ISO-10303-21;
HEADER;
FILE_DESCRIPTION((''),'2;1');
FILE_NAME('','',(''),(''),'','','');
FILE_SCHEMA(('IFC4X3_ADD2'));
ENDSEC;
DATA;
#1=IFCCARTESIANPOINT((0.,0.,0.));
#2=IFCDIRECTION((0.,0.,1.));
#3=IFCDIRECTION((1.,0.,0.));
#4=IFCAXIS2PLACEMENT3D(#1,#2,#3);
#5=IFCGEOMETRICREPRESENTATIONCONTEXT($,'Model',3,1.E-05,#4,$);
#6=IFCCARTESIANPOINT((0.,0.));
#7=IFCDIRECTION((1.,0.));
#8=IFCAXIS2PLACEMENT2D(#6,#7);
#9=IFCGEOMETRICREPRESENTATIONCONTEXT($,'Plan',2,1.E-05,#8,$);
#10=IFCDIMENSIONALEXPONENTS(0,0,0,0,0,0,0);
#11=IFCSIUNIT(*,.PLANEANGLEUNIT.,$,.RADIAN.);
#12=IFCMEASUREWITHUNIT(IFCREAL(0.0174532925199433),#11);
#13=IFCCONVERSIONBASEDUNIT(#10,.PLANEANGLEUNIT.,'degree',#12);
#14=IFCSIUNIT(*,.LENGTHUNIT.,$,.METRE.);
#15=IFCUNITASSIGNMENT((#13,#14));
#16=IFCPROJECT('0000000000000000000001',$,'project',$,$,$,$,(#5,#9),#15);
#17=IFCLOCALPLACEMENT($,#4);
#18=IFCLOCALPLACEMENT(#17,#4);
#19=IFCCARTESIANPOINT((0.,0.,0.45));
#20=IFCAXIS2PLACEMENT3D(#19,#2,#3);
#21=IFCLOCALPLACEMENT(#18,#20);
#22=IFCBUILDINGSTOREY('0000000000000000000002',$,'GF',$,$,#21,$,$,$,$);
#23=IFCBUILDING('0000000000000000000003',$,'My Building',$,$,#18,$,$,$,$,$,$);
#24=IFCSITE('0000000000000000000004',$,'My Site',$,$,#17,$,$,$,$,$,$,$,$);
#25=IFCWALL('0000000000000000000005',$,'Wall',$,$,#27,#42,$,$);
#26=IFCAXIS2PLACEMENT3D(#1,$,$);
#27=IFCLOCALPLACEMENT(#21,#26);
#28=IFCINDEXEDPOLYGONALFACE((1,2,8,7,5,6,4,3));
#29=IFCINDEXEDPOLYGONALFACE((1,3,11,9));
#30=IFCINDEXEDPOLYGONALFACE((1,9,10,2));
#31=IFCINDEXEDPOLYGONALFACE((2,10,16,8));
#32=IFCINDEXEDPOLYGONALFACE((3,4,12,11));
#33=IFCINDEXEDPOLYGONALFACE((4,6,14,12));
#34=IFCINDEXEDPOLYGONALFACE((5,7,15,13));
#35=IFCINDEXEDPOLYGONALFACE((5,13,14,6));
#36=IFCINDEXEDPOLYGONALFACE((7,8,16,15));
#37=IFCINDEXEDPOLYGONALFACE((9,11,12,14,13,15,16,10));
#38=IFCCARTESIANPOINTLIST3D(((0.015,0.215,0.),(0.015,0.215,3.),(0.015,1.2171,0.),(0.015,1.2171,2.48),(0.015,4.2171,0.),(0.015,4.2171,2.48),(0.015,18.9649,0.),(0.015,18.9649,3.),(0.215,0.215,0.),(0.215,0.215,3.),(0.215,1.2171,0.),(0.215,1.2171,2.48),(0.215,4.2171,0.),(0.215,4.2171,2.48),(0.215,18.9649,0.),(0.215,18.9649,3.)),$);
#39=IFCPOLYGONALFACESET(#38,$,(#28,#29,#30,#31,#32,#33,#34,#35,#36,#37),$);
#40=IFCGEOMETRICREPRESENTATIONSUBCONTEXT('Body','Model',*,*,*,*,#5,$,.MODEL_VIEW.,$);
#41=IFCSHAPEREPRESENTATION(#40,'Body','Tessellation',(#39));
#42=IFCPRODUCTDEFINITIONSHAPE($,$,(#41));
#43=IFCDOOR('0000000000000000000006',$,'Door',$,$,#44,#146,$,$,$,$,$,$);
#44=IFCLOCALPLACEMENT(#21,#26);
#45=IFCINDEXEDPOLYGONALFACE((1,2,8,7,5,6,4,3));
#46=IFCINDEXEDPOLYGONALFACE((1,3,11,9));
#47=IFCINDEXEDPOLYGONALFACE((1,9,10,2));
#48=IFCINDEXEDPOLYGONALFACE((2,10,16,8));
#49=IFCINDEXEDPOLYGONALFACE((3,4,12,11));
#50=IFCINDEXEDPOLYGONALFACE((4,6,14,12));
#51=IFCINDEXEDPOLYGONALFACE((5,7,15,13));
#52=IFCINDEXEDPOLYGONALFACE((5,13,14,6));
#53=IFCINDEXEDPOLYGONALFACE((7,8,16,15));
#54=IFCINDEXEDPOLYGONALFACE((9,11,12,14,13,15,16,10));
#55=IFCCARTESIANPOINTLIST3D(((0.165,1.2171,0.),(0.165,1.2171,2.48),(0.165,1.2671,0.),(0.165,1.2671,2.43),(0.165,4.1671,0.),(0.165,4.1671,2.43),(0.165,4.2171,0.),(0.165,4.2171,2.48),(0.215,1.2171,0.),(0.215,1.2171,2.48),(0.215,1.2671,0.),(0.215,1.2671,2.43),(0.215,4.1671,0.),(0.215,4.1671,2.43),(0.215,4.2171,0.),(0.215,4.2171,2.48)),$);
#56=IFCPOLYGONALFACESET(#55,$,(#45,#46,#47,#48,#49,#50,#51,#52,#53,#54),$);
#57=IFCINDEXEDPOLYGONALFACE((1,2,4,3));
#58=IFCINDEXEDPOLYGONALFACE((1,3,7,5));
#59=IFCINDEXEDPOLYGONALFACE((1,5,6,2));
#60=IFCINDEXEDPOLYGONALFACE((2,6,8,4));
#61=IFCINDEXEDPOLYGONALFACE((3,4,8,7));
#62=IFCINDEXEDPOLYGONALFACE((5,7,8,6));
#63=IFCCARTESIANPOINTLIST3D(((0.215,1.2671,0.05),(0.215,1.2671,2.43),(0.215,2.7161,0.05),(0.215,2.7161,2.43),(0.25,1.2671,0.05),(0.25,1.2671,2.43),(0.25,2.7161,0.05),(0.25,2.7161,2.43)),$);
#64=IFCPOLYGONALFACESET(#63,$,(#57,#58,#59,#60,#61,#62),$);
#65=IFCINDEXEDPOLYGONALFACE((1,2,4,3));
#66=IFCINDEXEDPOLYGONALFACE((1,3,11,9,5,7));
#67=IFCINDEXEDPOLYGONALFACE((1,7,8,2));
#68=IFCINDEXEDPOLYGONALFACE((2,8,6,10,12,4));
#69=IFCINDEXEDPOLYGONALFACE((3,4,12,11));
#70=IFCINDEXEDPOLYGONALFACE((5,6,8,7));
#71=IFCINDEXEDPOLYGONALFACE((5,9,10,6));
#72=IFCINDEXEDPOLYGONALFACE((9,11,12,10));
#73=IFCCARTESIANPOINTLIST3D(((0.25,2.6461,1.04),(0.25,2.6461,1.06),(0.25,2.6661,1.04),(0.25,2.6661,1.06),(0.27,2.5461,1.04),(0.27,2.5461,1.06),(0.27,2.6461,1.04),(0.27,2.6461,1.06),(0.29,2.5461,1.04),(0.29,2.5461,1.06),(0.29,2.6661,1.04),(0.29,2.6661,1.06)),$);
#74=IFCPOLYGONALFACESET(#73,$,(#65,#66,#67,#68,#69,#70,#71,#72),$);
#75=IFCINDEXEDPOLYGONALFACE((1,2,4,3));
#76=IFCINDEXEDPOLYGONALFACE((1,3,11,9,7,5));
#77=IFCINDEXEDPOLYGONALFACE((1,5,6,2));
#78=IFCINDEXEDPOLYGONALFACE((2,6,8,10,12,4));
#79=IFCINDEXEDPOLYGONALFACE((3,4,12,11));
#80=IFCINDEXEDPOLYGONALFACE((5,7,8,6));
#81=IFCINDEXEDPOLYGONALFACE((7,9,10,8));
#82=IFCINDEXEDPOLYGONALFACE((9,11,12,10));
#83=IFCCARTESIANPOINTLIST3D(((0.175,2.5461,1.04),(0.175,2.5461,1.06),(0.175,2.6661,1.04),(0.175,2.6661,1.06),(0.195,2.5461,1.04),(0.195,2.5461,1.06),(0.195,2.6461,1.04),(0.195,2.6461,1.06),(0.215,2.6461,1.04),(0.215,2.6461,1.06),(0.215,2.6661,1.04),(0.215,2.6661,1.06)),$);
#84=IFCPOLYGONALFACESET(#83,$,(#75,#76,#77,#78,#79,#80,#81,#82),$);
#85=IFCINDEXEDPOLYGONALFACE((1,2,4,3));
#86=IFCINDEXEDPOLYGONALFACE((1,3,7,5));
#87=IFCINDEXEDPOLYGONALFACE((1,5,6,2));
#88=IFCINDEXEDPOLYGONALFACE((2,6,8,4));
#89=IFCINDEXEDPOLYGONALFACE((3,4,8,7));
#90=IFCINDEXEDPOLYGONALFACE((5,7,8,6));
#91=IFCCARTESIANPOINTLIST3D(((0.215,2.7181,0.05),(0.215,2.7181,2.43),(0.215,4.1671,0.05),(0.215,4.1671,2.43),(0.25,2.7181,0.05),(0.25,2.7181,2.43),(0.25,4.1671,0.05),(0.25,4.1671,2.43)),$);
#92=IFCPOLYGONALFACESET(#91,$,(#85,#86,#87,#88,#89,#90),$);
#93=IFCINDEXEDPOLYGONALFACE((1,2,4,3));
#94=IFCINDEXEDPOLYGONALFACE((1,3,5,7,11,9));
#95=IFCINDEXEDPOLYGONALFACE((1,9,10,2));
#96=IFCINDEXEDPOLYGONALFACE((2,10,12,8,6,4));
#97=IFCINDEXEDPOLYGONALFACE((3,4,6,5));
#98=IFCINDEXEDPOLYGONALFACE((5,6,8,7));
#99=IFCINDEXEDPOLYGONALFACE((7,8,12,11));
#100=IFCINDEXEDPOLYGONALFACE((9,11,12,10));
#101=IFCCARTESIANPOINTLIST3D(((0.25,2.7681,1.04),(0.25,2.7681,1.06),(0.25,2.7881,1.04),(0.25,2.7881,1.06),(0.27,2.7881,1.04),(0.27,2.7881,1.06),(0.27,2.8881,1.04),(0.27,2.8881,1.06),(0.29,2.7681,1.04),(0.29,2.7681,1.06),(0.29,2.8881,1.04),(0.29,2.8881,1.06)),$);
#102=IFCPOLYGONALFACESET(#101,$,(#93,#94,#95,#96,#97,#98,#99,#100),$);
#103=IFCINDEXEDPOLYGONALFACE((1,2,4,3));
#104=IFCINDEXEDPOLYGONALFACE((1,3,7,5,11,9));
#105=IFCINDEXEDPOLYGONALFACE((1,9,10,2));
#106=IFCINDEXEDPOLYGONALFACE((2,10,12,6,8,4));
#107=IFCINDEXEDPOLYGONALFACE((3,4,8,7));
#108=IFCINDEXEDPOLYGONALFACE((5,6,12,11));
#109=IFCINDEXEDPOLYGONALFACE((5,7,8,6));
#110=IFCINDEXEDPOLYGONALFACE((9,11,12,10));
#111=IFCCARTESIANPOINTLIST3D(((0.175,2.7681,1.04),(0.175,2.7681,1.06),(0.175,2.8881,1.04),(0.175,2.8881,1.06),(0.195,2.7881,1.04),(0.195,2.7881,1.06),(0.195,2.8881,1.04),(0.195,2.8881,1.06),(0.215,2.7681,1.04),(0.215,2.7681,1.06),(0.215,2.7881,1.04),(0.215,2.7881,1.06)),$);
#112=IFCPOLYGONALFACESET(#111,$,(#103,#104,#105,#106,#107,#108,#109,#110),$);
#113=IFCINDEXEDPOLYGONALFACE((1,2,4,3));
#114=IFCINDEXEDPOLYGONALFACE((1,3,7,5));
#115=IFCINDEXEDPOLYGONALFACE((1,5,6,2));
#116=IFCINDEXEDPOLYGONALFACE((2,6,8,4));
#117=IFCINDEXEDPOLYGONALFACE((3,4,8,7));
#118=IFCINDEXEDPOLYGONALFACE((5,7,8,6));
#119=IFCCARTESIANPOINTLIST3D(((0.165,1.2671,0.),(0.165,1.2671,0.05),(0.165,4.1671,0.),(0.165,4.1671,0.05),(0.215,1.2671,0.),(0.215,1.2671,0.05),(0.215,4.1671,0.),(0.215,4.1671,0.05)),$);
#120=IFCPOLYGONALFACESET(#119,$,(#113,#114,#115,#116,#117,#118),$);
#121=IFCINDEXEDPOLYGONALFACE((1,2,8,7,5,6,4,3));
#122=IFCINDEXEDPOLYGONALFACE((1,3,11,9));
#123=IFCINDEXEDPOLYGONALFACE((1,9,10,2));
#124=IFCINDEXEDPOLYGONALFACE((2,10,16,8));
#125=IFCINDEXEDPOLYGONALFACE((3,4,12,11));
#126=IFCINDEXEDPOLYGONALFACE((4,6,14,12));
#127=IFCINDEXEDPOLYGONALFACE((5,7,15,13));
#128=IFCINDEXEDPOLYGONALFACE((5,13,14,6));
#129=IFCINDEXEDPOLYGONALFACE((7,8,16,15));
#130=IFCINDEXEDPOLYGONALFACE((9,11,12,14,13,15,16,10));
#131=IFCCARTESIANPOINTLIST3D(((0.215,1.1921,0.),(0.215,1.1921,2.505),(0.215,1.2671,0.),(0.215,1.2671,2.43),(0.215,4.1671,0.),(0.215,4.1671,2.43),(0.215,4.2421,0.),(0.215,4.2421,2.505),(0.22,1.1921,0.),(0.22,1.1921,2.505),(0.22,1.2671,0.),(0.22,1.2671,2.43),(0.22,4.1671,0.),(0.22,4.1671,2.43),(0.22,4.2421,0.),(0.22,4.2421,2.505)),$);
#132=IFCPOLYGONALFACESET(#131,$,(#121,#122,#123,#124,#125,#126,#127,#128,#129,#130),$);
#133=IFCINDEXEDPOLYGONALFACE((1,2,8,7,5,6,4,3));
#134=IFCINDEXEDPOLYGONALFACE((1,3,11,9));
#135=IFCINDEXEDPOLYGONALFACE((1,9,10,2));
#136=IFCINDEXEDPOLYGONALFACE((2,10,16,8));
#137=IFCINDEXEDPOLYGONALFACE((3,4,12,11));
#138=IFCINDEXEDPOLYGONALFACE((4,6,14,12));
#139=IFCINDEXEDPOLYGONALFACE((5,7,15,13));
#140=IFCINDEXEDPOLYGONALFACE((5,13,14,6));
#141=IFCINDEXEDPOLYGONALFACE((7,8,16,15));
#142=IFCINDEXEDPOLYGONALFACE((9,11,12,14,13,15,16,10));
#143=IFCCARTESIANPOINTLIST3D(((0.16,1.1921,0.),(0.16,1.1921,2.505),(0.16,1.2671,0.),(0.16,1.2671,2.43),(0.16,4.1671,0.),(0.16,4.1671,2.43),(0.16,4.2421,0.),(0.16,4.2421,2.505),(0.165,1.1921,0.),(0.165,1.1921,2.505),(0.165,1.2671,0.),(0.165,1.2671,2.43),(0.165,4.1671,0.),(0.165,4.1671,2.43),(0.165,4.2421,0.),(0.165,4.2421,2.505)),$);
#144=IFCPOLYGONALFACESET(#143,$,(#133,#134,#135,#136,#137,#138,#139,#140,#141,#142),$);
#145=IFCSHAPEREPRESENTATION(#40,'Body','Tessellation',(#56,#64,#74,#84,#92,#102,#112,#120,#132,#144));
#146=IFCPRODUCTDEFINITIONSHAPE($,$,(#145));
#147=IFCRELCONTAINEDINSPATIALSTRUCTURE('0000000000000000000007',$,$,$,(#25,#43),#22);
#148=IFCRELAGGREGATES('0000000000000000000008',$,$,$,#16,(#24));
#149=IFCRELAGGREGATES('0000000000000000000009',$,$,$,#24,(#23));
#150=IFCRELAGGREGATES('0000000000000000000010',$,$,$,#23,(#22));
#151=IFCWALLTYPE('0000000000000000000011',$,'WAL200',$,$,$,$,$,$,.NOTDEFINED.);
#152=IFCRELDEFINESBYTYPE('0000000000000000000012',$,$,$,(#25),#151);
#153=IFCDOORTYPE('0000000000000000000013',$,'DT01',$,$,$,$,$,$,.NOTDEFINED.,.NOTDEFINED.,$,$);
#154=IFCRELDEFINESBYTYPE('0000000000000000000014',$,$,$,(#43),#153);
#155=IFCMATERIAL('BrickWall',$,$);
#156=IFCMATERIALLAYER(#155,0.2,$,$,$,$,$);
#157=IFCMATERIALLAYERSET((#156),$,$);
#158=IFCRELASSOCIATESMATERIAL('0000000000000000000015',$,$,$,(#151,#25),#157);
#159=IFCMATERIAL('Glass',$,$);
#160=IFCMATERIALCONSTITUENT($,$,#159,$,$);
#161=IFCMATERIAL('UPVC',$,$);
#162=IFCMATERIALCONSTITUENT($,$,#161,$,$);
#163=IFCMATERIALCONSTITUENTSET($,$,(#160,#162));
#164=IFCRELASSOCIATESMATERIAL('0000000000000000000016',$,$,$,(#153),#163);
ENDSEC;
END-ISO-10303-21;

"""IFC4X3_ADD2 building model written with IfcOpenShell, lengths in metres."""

from ifc_helpers import new_model, entity, si_unit, converted_unit, frame, origin_with_axes, origin_2d_with_axis, place, context, subcontext, project, spatial, line, indexed_curve, outline, extrude, shape, source, transform, mapped, material, layer, layer_set, layer_usage, constituent, constituent_set, type_object, type_shapes, element, fill, save


model = new_model("IFC4X3_ADD2")

# Units and contexts
model_context = context("Model", 3, precision=1e-05, world=origin_with_axes())
plan_context = context("Plan", 2, precision=1e-05, world=origin_2d_with_axis())
body_context_1 = subcontext(model_context, "Body", "Model", "MODEL_VIEW")
body_context_2 = subcontext(plan_context, "Body", "Plan", "PLAN_VIEW")
ifc_project = project(units=[converted_unit("PLANEANGLEUNIT", "degree", entity("IfcReal", 0.0174532925199433), si_unit("PLANEANGLEUNIT", "RADIAN"), dimensions=[0, 0, 0, 0, 0, 0, 0]), si_unit("LENGTHUNIT", "METRE")], contexts=[model_context, plan_context])

# Site, building, storey
site_placement = place(None, origin_with_axes())
site = spatial("IfcSite", under=ifc_project, at=site_placement, Name="My Site")
building_placement = place(site_placement, origin_with_axes())
building = spatial("IfcBuilding", under=site, at=building_placement, Name="My Building")
storey_placement = place(building_placement, frame((0.0, 0.0, 0.45), z_axis=(0.0, 0.0, 1.0), x_axis=(1.0, 0.0, 0.0)))
storey = spatial("IfcBuildingStorey", under=building, at=storey_placement, Name="GF")

# Shared definitions
ifc_material_1 = material(Name="BrickWall")

# Wall, opening, door
ifc_layer_1 = layer(ifc_material_1, 0.2)
ifc_layer_set_1 = layer_set([ifc_layer_1])
ifc_layer_usage_1 = layer_usage(ifc_layer_set_1, "AXIS2", "POSITIVE", 0.0)
wall_type_1 = type_object("IfcWallType", Name="WAL200", PredefinedType="NOTDEFINED", material=ifc_layer_set_1)
wall_1_placement = place(storey_placement, frame((0.215, 0.215, 0.0), z_axis=(0.0, 0.0, 1.0), x_axis=(0.0, 1.0, 0.0)))
wall_1 = element("IfcWall", 1, at=wall_1_placement, inside=storey, type_object=wall_type_1, material=ifc_layer_usage_1, Name="Wall", context=body_context_1, shape_type="SweptSolid", body=[
    extrude(outline(indexed_curve([(0.0, 0.0), (0.0, 0.2), (18.7499, 0.2), (18.7499, 0.0), (0.0, 0.0)], self_intersect=False)), origin_with_axes(), (0.0, 0.0, 1.0), 3.0),
])
shared_shape_1 = source(origin_with_axes(), body_context_1, "Body", "SweptSolid", [
    extrude(outline(indexed_curve([(0.0, 0.0), (3.0, 0.0), (3.0, 2.48), (0.0, 2.48)], segments=[line(1, 2, 3, 4, 1)])), frame((0.0, -0.6, 0.0), z_axis=(0.0, -1.0, 0.0), x_axis=(1.0, 0.0, 0.0)), (0.0, 0.0, -1.0), 1.2),
])
opening_1_placement = place(wall_1_placement, frame((1.0021, 0.0, 0.0), z_axis=(0.0, 0.0, 1.0), x_axis=(1.0, 0.0, 0.0)))
opening_1 = element("IfcOpeningElement", 2, at=opening_1_placement, cuts=wall_1, PredefinedType="OPENING", context=body_context_1, shape_type="MappedRepresentation", body=[
    mapped(shared_shape_1, transform((0.0, 0.0, 0.0), x_axis=(1.0, 0.0, 0.0), y_axis=(0.0, 1.0, 0.0), z_axis=(0.0, 0.0, 1.0), scale=1.0)),
])
ifc_material_2 = material(Name="Glass")
ifc_constituent_1 = constituent(ifc_material_2)
ifc_material_3 = material(Name="UPVC")
ifc_constituent_2 = constituent(ifc_material_3)
ifc_constituent_set = constituent_set(constituents=[ifc_constituent_1, ifc_constituent_2])
door_type_1 = type_object("IfcDoorType", Name="DT01", OperationType="NOTDEFINED", PredefinedType="NOTDEFINED", material=ifc_constituent_set)
shared_shape_2 = source(origin_with_axes(), body_context_1, "Body", "SweptSolid", [
    extrude(outline(indexed_curve([(3.0, 0.0), (3.0, 2.48), (0.0, 2.48), (0.0, 0.0), (0.05, 0.0), (0.05, 2.43), (2.95, 2.43), (2.95, 0.0)], segments=[line(5, 4), line(4, 3), line(3, 2), line(2, 1), line(1, 8), line(8, 7), line(7, 6), line(6, 5)], self_intersect=False)), frame((0.0, 0.0, 0.0), z_axis=(0.0, -1.0, 0.0), x_axis=(1.0, 0.0, 0.0)), (0.0, 0.0, -1.0), 0.05),
    extrude(outline(indexed_curve([(0.0, 0.0), (1.449, 0.0), (1.449, 0.035), (0.0, 0.035)], segments=[line(1, 2, 3, 4, 1)])), frame((0.05, -0.035, 0.05), z_axis=(0.0, 0.0, 1.0), x_axis=(1.0, 0.0, 0.0)), (0.0, 0.0, 1.0), 2.38),
    extrude(outline(indexed_curve([(0.0, 0.0), (0.0, -0.04), (-0.12, -0.04), (-0.12, -0.02), (-0.02, -0.02), (-0.02, 0.0)], segments=[line(1, 2, 3, 4, 5, 6, 1)])), frame((1.449, -0.035, 1.04), z_axis=(0.0, 0.0, 1.0), x_axis=(1.0, 0.0, 0.0)), (0.0, 0.0, 1.0), 0.02),
    extrude(outline(indexed_curve([(0.0, 0.0), (0.0, 0.04), (-0.12, 0.04), (-0.12, 0.02), (-0.02, 0.02), (-0.02, 0.0)], segments=[line(1, 2, 3, 4, 5, 6, 1)])), frame((1.449, 0.0, 1.04), z_axis=(0.0, 0.0, 1.0), x_axis=(1.0, 0.0, 0.0)), (0.0, 0.0, 1.0), 0.02),
    extrude(outline(indexed_curve([(0.0, 0.0), (-1.449, 0.0), (-1.449, 0.035), (0.0, 0.035)], segments=[line(1, 2, 3, 4, 1)])), frame((2.95, -0.035, 0.05), z_axis=(0.0, 0.0, 1.0), x_axis=(1.0, 0.0, 0.0)), (0.0, 0.0, 1.0), 2.38),
    extrude(outline(indexed_curve([(0.0, 0.0), (0.0, -0.04), (0.12, -0.04), (0.12, -0.02), (0.02, -0.02), (0.02, 0.0)], segments=[line(1, 2, 3, 4, 5, 6, 1)])), frame((1.551, -0.035, 1.04), z_axis=(0.0, 0.0, 1.0), x_axis=(1.0, 0.0, 0.0)), (0.0, 0.0, 1.0), 0.02),
    extrude(outline(indexed_curve([(0.0, 0.0), (0.0, 0.04), (0.12, 0.04), (0.12, 0.02), (0.02, 0.02), (0.02, 0.0)], segments=[line(1, 2, 3, 4, 5, 6, 1)])), frame((1.551, 0.0, 1.04), z_axis=(0.0, 0.0, 1.0), x_axis=(1.0, 0.0, 0.0)), (0.0, 0.0, 1.0), 0.02),
    extrude(outline(indexed_curve([(0.0, 0.0), (2.9, 0.0), (2.9, 0.05), (0.0, 0.05)], segments=[line(1, 2, 3, 4, 1)])), frame((0.05, 0.0, 0.0), z_axis=(0.0, 0.0, 1.0), x_axis=(1.0, 0.0, 0.0)), (0.0, 0.0, 1.0), 0.05),
    extrude(outline(indexed_curve([(0.0, 0.0), (0.0, 2.505), (3.05, 2.505), (3.05, 0.0), (2.975, 0.0), (2.975, 2.43), (0.075, 2.43), (0.075, 0.0)], segments=[line(1, 2, 3, 4, 5, 6, 7, 8, 1)])), frame((-0.025, -0.005, 0.0), z_axis=(0.0, -1.0, 0.0), x_axis=(1.0, 0.0, 0.0)), (0.0, 0.0, -1.0), 0.005),
    extrude(outline(indexed_curve([(0.0, 0.0), (0.0, 2.505), (3.05, 2.505), (3.05, 0.0), (2.975, 0.0), (2.975, 2.43), (0.075, 2.43), (0.075, 0.0)], segments=[line(1, 2, 3, 4, 5, 6, 7, 8, 1)])), frame((-0.025, 0.05, 0.0), z_axis=(0.0, -1.0, 0.0), x_axis=(1.0, 0.0, 0.0)), (0.0, 0.0, -1.0), 0.005),
])
shared_shape_3 = source(origin_with_axes(), body_context_2, "Body", "Curve2D", [
    entity("IfcIndexedPolyCurve", entity("IfcCartesianPointList2D", [[0.0, 0.0], [0.05, 0.0], [0.05, 0.05], [0.0, 0.05]]), [entity("IfcLineIndex", [1, 2, 3, 4, 1])]),
    entity("IfcIndexedPolyCurve", entity("IfcCartesianPointList2D", [[3.0, 0.0], [2.95, 0.0], [2.95, 0.05], [3.0, 0.05]]), [entity("IfcLineIndex", [1, 2, 3, 4, 1])]),
    entity("IfcIndexedPolyCurve", entity("IfcCartesianPointList2D", [[-0.675, -0.035], [0.775, -0.035], [0.775, 0.0], [-0.675, 0.0]]), [entity("IfcLineIndex", [1, 2, 3, 4, 1])]),
    entity("IfcIndexedPolyCurve", entity("IfcCartesianPointList2D", [[3.675, -0.035], [2.225, -0.035], [2.225, 0.0], [3.675, 0.0]]), [entity("IfcLineIndex", [1, 2, 3, 4, 1])]),
])
type_shapes(door_type_1, [shared_shape_2, shared_shape_3])
door_1_placement = place(opening_1_placement, frame((0.0, 0.0, 0.0), z_axis=(0.0, 0.0, 1.0), x_axis=(1.0, 0.0, 0.0)))
door_1 = element("IfcDoor", 3, at=door_1_placement, inside=storey, type_object=door_type_1, Name="Door", shapes=[
    shape(body_context_1, "Body", "MappedRepresentation", [mapped(shared_shape_2, transform((0.0, 0.0, 0.0), x_axis=(1.0, 0.0, 0.0), y_axis=(0.0, 1.0, 0.0), z_axis=(0.0, 0.0, 1.0), scale=1.0))]),
    shape(body_context_2, "Body", "MappedRepresentation", [mapped(shared_shape_3, transform((0.0, 0.0, 0.0), x_axis=(1.0, 0.0, 0.0), y_axis=(0.0, 1.0, 0.0), z_axis=(0.0, 0.0, 1.0), scale=1.0))]),
])
fill(opening_1, door_1)

save(model, "model.ifc")
